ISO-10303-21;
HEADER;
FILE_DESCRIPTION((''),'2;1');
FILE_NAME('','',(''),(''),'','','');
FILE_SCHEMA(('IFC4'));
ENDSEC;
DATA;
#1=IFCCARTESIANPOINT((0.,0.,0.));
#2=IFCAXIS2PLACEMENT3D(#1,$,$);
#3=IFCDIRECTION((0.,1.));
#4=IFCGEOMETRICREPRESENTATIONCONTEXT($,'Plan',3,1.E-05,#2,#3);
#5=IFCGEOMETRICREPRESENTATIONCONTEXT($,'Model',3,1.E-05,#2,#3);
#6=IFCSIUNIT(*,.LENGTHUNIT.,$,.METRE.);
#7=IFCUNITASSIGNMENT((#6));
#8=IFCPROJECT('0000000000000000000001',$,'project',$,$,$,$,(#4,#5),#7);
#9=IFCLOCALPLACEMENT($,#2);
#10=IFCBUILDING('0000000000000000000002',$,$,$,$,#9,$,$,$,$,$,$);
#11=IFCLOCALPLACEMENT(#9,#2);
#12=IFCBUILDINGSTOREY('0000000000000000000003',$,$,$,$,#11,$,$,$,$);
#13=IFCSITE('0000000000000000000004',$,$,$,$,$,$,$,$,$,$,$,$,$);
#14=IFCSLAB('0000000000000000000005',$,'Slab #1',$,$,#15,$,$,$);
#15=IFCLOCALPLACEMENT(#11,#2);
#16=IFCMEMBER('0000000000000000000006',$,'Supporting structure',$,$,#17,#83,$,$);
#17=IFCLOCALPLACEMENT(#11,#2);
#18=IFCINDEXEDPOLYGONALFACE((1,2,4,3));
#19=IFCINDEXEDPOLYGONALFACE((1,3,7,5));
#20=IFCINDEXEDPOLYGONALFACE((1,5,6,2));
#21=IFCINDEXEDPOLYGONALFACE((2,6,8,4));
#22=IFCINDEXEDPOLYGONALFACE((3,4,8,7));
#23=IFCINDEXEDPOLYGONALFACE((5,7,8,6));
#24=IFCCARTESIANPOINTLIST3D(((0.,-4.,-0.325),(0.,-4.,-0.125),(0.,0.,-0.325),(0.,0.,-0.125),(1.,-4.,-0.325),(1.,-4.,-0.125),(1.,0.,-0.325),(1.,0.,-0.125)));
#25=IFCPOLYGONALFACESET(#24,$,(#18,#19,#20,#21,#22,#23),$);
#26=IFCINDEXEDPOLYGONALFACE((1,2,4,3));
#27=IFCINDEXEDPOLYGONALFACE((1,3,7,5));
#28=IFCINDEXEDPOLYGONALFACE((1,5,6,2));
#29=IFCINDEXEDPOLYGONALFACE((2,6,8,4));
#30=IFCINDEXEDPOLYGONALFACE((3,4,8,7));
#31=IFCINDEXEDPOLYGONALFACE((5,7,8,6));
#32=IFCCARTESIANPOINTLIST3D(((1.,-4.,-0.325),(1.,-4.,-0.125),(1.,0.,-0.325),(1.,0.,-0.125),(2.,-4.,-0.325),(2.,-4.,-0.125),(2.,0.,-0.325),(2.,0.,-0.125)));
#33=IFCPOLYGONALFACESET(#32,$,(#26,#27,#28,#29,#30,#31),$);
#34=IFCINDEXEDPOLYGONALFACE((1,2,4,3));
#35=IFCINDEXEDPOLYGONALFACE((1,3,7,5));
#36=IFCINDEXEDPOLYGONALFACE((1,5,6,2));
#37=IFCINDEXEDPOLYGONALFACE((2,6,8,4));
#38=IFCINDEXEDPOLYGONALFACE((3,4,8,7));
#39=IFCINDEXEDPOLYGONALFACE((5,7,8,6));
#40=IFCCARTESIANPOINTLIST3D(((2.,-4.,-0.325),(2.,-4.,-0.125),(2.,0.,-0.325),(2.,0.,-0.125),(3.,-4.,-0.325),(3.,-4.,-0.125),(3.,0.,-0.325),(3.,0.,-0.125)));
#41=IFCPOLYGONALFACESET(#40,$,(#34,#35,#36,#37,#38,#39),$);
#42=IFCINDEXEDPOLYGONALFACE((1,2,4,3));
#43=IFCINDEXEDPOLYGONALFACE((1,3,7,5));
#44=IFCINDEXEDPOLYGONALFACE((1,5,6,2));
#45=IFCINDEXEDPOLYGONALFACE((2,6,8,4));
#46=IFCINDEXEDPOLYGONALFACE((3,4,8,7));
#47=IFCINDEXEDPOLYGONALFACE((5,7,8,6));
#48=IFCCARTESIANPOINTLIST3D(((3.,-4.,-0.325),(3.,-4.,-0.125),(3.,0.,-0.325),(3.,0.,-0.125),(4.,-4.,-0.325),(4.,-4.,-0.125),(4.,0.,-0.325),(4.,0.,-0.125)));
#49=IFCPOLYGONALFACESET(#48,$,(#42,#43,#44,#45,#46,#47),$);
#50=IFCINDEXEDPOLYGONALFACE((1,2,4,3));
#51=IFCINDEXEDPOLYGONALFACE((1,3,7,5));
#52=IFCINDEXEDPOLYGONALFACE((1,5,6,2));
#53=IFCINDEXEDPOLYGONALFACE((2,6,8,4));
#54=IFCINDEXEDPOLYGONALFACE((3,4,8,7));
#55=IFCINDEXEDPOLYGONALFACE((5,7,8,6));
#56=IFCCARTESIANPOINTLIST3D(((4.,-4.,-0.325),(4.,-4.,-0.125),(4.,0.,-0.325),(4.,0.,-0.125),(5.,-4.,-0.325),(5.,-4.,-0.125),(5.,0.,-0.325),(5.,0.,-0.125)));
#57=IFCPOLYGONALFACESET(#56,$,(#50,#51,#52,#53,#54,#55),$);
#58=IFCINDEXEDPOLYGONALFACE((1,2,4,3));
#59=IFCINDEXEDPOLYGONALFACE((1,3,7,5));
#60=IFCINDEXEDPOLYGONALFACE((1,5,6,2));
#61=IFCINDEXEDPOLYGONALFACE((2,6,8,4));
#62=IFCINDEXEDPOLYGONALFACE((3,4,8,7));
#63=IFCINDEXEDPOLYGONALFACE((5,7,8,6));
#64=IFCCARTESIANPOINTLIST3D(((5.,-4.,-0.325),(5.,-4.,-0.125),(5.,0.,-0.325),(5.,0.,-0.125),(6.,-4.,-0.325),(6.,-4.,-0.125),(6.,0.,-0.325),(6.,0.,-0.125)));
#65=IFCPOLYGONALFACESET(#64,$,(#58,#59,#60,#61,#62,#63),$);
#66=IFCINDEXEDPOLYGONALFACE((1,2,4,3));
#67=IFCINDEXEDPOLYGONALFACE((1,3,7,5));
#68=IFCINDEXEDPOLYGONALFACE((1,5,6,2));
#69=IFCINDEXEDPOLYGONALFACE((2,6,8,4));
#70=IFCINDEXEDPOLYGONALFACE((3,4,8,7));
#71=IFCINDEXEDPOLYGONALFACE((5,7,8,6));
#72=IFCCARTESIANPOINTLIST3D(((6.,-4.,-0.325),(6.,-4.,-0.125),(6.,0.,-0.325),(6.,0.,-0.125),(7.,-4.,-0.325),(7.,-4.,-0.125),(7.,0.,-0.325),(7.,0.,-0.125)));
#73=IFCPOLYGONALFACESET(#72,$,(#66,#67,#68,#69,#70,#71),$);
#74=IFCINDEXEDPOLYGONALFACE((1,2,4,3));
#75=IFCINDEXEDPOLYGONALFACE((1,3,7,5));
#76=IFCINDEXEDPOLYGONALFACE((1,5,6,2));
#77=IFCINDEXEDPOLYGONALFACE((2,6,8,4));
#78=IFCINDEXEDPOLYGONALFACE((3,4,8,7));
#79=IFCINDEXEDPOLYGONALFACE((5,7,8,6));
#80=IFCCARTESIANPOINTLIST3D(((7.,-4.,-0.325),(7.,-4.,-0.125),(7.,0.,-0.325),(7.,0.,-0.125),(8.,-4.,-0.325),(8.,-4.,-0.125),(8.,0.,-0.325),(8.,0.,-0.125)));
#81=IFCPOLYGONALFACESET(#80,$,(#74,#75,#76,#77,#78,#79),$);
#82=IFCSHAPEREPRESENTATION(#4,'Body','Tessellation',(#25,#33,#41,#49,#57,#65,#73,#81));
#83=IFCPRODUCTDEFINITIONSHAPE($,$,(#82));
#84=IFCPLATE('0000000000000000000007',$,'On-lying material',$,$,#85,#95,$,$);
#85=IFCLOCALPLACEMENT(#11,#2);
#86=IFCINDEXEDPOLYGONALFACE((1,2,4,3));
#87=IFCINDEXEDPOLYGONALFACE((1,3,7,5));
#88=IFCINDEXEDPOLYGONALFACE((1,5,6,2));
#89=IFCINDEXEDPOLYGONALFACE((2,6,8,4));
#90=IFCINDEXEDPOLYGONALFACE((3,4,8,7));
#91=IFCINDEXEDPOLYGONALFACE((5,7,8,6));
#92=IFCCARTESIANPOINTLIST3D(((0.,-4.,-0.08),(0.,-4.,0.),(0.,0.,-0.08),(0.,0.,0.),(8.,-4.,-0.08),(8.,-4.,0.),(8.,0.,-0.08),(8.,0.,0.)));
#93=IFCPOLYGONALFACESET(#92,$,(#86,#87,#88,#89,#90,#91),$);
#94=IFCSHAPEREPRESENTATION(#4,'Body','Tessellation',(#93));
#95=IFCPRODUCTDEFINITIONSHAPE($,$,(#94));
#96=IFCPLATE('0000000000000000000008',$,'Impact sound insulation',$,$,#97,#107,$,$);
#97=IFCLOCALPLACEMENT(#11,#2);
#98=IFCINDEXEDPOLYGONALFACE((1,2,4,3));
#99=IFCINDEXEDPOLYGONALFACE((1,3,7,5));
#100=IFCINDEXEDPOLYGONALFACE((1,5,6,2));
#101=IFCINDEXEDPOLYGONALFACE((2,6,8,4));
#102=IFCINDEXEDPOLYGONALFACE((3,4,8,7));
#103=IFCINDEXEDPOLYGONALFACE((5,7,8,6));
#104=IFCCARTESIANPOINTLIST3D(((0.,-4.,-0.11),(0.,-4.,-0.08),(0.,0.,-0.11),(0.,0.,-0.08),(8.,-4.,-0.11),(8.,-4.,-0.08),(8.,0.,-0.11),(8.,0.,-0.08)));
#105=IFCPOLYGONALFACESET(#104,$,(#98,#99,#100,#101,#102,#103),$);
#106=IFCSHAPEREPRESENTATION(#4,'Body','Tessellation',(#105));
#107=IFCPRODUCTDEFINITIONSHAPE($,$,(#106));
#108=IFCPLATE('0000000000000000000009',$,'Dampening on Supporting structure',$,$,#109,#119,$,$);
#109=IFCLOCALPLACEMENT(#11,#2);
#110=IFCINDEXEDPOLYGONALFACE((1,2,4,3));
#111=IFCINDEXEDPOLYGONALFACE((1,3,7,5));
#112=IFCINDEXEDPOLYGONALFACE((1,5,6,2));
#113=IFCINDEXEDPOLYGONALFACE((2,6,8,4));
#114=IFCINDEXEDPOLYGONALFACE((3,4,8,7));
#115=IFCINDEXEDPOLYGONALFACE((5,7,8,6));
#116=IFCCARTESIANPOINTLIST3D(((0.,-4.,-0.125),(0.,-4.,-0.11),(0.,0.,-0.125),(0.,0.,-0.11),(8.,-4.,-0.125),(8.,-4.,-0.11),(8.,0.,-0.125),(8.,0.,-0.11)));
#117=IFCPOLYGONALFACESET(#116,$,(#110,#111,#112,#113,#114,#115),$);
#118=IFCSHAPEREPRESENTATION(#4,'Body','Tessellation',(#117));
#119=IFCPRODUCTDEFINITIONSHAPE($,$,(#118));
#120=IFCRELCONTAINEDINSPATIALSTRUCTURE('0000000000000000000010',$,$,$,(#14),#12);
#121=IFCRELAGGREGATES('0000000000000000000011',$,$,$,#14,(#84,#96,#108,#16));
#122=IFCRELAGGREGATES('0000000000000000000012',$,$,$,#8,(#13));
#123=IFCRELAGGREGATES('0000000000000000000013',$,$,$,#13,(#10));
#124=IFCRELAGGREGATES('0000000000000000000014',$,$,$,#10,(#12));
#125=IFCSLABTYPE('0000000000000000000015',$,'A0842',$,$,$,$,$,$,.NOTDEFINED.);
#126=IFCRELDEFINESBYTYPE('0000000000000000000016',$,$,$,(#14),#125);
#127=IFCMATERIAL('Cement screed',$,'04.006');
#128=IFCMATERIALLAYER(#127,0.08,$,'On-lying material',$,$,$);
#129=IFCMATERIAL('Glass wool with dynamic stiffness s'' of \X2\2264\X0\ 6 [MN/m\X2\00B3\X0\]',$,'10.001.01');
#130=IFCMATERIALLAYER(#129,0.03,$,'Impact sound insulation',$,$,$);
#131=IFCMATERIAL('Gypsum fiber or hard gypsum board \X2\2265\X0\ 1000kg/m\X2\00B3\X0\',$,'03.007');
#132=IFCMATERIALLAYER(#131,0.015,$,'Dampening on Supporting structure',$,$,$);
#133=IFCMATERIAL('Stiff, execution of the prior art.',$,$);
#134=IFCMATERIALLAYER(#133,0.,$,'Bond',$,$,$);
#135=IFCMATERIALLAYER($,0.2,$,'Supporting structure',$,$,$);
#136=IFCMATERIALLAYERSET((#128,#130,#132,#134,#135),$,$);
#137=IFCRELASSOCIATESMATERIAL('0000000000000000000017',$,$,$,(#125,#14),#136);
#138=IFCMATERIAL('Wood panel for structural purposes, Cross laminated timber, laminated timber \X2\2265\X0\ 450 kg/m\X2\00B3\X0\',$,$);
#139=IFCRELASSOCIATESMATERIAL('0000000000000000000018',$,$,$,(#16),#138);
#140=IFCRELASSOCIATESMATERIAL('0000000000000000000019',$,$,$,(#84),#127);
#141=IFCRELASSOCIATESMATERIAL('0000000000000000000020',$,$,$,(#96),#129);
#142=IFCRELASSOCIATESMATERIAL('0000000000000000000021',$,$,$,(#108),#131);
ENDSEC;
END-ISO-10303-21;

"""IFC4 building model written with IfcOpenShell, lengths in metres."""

from ifc_helpers import new_model, si_unit, direction, frame, frame_2d, origin, origin_with_axes, place, context, project, spatial, rectangle, extrude, material, layer, layer_set, type_object, element, aggregate, save


model = new_model("IFC4")

# Units and contexts
plan_context = context("Plan", 3, precision=1e-05, world=origin(), true_north=direction((0.0, 1.0)))
model_context = context("Model", 3, precision=1e-05, world=origin(), true_north=direction((0.0, 1.0)))
ifc_project = project(units=[si_unit("LENGTHUNIT", "METRE")], contexts=[plan_context, model_context])

# Site, building, storey
site = spatial("IfcSite", under=ifc_project)
building_placement = place(None, origin())
building = spatial("IfcBuilding", under=site, at=building_placement)
storey_placement = place(building_placement, origin())
storey = spatial("IfcBuildingStorey", under=building, at=storey_placement)

# Slab, member, plates
ifc_material_1 = material(Name="Cement screed", Category="04.006")
ifc_layer_1 = layer(ifc_material_1, 0.08, Name="On-lying material")
ifc_material_2 = material(Name="Glass wool with dynamic stiffness s' of ≤ 6 [MN/m³]", Category="10.001.01")
ifc_layer_2 = layer(ifc_material_2, 0.03, Name="Impact sound insulation")
ifc_material_3 = material(Name="Gypsum fiber or hard gypsum board ≥ 1000kg/m³", Category="03.007")
ifc_layer_3 = layer(ifc_material_3, 0.015, Name="Dampening on Supporting structure")
ifc_material_4 = material(Name="Stiff, execution of the prior art.")
ifc_layer_4 = layer(ifc_material_4, 0.0, Name="Bond")
ifc_layer_5 = layer(None, 0.2, Name="Supporting structure")
ifc_layer_set = layer_set([ifc_layer_1, ifc_layer_2, ifc_layer_3, ifc_layer_4, ifc_layer_5])
slab_type = type_object("IfcSlabType", Name="A0842", PredefinedType="NOTDEFINED", material=ifc_layer_set)
slab_placement = place(None, frame((0.0, 0.0, 0.0), z_axis=(0.0, 0.0, -1.0), x_axis=(1.0, 0.0, 0.0)))
slab = element("IfcSlab", 1, at=slab_placement, inside=storey, type_object=slab_type, material=ifc_layer_set, Name="Slab #1")
ifc_material_5 = material(Name="Wood panel for structural purposes, Cross laminated timber, laminated timber ≥ 450 kg/m³")
member_placement = place(slab_placement, origin())
member = element("IfcMember", 2, at=member_placement, material=ifc_material_5, Name="Supporting structure", context=plan_context, shape_type="SweptSolid", body=[
    extrude(rectangle(XDim=1.0, YDim=0.2, at=frame_2d((0.5, 0.1), x_axis=(1.0, 0.0))), frame((0.0, 4.0, 0.125), z_axis=(0.0, -1.0, 0.0), x_axis=(1.0, 0.0, 0.0)), (0.0, 0.0, 1.0), 4.0),
    extrude(rectangle(XDim=1.0, YDim=0.2, at=frame_2d((0.5, 0.1), x_axis=(1.0, 0.0))), frame((1.0, 4.0, 0.125), z_axis=(0.0, -1.0, 0.0), x_axis=(1.0, 0.0, 0.0)), (0.0, 0.0, 1.0), 4.0),
    extrude(rectangle(XDim=1.0, YDim=0.2, at=frame_2d((0.5, 0.1), x_axis=(1.0, 0.0))), frame((2.0, 4.0, 0.125), z_axis=(0.0, -1.0, 0.0), x_axis=(1.0, 0.0, 0.0)), (0.0, 0.0, 1.0), 4.0),
    extrude(rectangle(XDim=1.0, YDim=0.2, at=frame_2d((0.5, 0.1), x_axis=(1.0, 0.0))), frame((3.0, 4.0, 0.125), z_axis=(0.0, -1.0, 0.0), x_axis=(1.0, 0.0, 0.0)), (0.0, 0.0, 1.0), 4.0),
    extrude(rectangle(XDim=1.0, YDim=0.2, at=frame_2d((0.5, 0.1), x_axis=(1.0, 0.0))), frame((4.0, 4.0, 0.125), z_axis=(0.0, -1.0, 0.0), x_axis=(1.0, 0.0, 0.0)), (0.0, 0.0, 1.0), 4.0),
    extrude(rectangle(XDim=1.0, YDim=0.2, at=frame_2d((0.5, 0.1), x_axis=(1.0, 0.0))), frame((5.0, 4.0, 0.125), z_axis=(0.0, -1.0, 0.0), x_axis=(1.0, 0.0, 0.0)), (0.0, 0.0, 1.0), 4.0),
    extrude(rectangle(XDim=1.0, YDim=0.2, at=frame_2d((0.5, 0.1), x_axis=(1.0, 0.0))), frame((6.0, 4.0, 0.125), z_axis=(0.0, -1.0, 0.0), x_axis=(1.0, 0.0, 0.0)), (0.0, 0.0, 1.0), 4.0),
    extrude(rectangle(XDim=1.0, YDim=0.2, at=frame_2d((0.5, 0.1), x_axis=(1.0, 0.0))), frame((7.0, 4.0, 0.125), z_axis=(0.0, -1.0, 0.0), x_axis=(1.0, 0.0, 0.0)), (0.0, 0.0, 1.0), 4.0),
])
plate_1_placement = place(slab_placement, origin())
plate_1 = element("IfcPlate", 3, at=plate_1_placement, material=ifc_material_1, Name="On-lying material", context=plan_context, shape_type="SweptSolid", body=[
    extrude(rectangle(XDim=8.0, YDim=4.0, at=frame_2d((4.0, 2.0), x_axis=(1.0, 0.0))), origin_with_axes(), (0.0, 0.0, 1.0), 0.08),
])
plate_2_placement = place(slab_placement, origin())
plate_2 = element("IfcPlate", 4, at=plate_2_placement, material=ifc_material_2, Name="Impact sound insulation", context=plan_context, shape_type="SweptSolid", body=[
    extrude(rectangle(XDim=8.0, YDim=4.0, at=frame_2d((4.0, 2.0), x_axis=(1.0, 0.0))), frame((0.0, 0.0, 0.08), z_axis=(0.0, 0.0, 1.0), x_axis=(1.0, 0.0, 0.0)), (0.0, 0.0, 1.0), 0.03),
])
plate_3_placement = place(slab_placement, origin())
plate_3 = element("IfcPlate", 5, at=plate_3_placement, material=ifc_material_3, Name="Dampening on Supporting structure", context=plan_context, shape_type="SweptSolid", body=[
    extrude(rectangle(XDim=8.0, YDim=4.0, at=frame_2d((4.0, 2.0), x_axis=(1.0, 0.0))), frame((0.0, 0.0, 0.11), z_axis=(0.0, 0.0, 1.0), x_axis=(1.0, 0.0, 0.0)), (0.0, 0.0, 1.0), 0.015),
])
aggregate(slab, [plate_1, plate_2, plate_3, member])

save(model, "model.ifc")
